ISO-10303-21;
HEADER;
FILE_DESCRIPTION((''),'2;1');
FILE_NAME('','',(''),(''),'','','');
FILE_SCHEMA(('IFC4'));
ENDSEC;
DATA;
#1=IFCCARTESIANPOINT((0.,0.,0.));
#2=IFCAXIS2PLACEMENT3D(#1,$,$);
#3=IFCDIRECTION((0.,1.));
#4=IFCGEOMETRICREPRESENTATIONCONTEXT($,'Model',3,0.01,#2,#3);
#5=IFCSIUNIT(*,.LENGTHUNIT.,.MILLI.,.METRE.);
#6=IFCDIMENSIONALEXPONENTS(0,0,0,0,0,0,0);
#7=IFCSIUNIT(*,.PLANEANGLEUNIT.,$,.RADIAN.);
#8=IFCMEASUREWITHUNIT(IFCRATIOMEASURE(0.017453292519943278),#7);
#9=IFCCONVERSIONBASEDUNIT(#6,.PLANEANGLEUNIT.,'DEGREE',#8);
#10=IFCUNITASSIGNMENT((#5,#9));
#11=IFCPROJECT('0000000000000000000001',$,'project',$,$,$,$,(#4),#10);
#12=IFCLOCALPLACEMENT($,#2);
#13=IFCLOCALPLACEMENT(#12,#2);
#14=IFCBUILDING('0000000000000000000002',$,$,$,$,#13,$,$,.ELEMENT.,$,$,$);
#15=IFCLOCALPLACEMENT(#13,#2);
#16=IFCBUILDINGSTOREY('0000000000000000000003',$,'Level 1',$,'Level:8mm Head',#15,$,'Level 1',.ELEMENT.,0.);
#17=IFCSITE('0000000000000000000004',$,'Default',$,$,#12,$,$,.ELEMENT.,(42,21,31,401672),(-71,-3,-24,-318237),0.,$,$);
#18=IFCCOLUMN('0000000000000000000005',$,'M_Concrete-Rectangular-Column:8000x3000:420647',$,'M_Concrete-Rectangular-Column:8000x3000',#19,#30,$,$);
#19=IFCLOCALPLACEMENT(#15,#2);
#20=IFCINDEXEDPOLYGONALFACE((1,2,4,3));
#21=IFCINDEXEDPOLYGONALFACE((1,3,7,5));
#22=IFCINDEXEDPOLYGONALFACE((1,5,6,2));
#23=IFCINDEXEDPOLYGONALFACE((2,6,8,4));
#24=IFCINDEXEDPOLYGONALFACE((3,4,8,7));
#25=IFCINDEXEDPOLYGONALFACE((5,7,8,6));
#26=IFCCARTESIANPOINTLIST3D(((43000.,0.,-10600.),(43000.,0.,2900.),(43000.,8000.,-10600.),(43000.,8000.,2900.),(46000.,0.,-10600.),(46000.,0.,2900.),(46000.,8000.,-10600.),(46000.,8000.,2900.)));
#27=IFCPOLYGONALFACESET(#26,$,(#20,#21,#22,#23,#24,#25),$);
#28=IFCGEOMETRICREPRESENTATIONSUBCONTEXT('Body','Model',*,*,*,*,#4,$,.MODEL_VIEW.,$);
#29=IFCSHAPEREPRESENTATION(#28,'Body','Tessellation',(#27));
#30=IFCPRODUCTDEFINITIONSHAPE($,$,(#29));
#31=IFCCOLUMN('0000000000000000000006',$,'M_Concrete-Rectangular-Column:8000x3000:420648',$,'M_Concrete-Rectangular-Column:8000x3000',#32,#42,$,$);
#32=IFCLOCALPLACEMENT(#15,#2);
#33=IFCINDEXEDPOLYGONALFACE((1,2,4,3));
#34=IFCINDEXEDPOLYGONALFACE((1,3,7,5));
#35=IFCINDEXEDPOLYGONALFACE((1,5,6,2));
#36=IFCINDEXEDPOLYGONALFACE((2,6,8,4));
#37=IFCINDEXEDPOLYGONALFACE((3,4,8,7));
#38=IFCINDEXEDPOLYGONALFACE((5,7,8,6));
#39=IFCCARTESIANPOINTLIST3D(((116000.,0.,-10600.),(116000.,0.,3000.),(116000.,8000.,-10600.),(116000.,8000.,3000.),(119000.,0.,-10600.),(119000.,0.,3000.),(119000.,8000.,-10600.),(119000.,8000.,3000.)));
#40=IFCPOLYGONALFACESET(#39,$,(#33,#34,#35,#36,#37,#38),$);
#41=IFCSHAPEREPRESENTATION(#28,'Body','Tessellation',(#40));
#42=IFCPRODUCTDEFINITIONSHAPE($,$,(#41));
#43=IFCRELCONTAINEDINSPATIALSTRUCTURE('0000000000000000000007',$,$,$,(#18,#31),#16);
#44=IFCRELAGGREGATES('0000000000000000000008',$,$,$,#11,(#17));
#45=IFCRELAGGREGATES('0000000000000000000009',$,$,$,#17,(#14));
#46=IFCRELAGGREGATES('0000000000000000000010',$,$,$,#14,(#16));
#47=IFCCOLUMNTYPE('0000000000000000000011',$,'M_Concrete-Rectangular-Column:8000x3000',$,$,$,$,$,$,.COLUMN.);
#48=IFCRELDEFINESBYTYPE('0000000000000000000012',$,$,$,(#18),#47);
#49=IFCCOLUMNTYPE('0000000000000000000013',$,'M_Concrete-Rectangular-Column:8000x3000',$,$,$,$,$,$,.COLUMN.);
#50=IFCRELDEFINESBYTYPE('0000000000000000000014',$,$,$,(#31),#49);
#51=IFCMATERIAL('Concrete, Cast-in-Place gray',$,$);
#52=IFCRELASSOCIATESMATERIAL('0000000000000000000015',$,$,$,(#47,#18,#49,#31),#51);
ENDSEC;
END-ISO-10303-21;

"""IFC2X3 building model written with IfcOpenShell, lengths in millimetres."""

from ifc_helpers import new_model, entity, si_unit, converted_unit, direction, frame, origin, origin_2d_with_axis, place, context, subcontext, project, spatial, rectangle, extrude, source, transform, mapped, material, type_object, type_shapes, element, save


model = new_model("IFC2X3")

# Units and contexts
model_context = context("Model", 3, precision=0.01, world=origin(), true_north=direction((0.0, 1.0)))
body_context = subcontext(model_context, "Body", "Model", "MODEL_VIEW")
ifc_project = project(units=[si_unit("LENGTHUNIT", "METRE", prefix="MILLI"), converted_unit("PLANEANGLEUNIT", "DEGREE", entity("IfcRatioMeasure", 0.017453292519943278), si_unit("PLANEANGLEUNIT", "RADIAN"), dimensions=[0, 0, 0, 0, 0, 0, 0])], contexts=[model_context])

# Site, building, storey
site_placement = place(None, origin())
site = spatial("IfcSite", under=ifc_project, at=site_placement, Name="Default", CompositionType="ELEMENT", RefLatitude=(42, 21, 31, 401672), RefLongitude=(-71, -3, -24, -318237), RefElevation=0.0)
building_placement = place(site_placement, origin())
building = spatial("IfcBuilding", under=site, at=building_placement, CompositionType="ELEMENT")
storey_placement = place(building_placement, origin())
storey = spatial("IfcBuildingStorey", under=building, at=storey_placement, Name="Level 1", ObjectType="Level:8mm Head", LongName="Level 1", CompositionType="ELEMENT", Elevation=0.0)

# Columns
ifc_material = material(Name="Concrete, Cast-in-Place gray")
column_type_1 = type_object("IfcColumnType", Name="M_Concrete-Rectangular-Column:8000x3000", PredefinedType="COLUMN", material=ifc_material)
shared_shape_1 = source(origin(), body_context, "Body", "SweptSolid", [
    extrude(rectangle(XDim=3000.0, YDim=8000.0, at=origin_2d_with_axis()), frame((0.0, 0.0, -10600.0), z_axis=(0.0, 0.0, 1.0), x_axis=(0.0, -1.0, 0.0)), (0.0, 0.0, 1.0), 13500.0),
])
type_shapes(column_type_1, [shared_shape_1])
column_1_placement = place(storey_placement, frame((44500.0, 4000.0, 0.0), z_axis=(0.0, 0.0, 1.0), x_axis=(0.0, -1.0, 0.0)))
element("IfcColumn", 1, at=column_1_placement, inside=storey, type_object=column_type_1, material=ifc_material, Name="M_Concrete-Rectangular-Column:8000x3000:420647", ObjectType="M_Concrete-Rectangular-Column:8000x3000", context=body_context, shape_type="MappedRepresentation", body=[
    mapped(shared_shape_1, transform((0.0, 0.0, 0.0), scale=1.0)),
])
column_type_2 = type_object("IfcColumnType", Name="M_Concrete-Rectangular-Column:8000x3000", PredefinedType="COLUMN", material=ifc_material)
shared_shape_2 = source(origin(), body_context, "Body", "SweptSolid", [
    extrude(rectangle(XDim=3000.0, YDim=8000.0, at=origin_2d_with_axis()), frame((0.0, 0.0, -10600.0), z_axis=(0.0, 0.0, 1.0), x_axis=(0.0, -1.0, 0.0)), (0.0, 0.0, 1.0), 13600.0),
])
type_shapes(column_type_2, [shared_shape_2])
column_2_placement = place(storey_placement, frame((117500.0, 4000.0, 0.0), z_axis=(0.0, 0.0, 1.0), x_axis=(0.0, 1.0, 0.0)))
element("IfcColumn", 2, at=column_2_placement, inside=storey, type_object=column_type_2, material=ifc_material, Name="M_Concrete-Rectangular-Column:8000x3000:420648", ObjectType="M_Concrete-Rectangular-Column:8000x3000", context=body_context, shape_type="MappedRepresentation", body=[
    mapped(shared_shape_2, transform((0.0, 0.0, 0.0), scale=1.0)),
])

save(model, "model.ifc")
